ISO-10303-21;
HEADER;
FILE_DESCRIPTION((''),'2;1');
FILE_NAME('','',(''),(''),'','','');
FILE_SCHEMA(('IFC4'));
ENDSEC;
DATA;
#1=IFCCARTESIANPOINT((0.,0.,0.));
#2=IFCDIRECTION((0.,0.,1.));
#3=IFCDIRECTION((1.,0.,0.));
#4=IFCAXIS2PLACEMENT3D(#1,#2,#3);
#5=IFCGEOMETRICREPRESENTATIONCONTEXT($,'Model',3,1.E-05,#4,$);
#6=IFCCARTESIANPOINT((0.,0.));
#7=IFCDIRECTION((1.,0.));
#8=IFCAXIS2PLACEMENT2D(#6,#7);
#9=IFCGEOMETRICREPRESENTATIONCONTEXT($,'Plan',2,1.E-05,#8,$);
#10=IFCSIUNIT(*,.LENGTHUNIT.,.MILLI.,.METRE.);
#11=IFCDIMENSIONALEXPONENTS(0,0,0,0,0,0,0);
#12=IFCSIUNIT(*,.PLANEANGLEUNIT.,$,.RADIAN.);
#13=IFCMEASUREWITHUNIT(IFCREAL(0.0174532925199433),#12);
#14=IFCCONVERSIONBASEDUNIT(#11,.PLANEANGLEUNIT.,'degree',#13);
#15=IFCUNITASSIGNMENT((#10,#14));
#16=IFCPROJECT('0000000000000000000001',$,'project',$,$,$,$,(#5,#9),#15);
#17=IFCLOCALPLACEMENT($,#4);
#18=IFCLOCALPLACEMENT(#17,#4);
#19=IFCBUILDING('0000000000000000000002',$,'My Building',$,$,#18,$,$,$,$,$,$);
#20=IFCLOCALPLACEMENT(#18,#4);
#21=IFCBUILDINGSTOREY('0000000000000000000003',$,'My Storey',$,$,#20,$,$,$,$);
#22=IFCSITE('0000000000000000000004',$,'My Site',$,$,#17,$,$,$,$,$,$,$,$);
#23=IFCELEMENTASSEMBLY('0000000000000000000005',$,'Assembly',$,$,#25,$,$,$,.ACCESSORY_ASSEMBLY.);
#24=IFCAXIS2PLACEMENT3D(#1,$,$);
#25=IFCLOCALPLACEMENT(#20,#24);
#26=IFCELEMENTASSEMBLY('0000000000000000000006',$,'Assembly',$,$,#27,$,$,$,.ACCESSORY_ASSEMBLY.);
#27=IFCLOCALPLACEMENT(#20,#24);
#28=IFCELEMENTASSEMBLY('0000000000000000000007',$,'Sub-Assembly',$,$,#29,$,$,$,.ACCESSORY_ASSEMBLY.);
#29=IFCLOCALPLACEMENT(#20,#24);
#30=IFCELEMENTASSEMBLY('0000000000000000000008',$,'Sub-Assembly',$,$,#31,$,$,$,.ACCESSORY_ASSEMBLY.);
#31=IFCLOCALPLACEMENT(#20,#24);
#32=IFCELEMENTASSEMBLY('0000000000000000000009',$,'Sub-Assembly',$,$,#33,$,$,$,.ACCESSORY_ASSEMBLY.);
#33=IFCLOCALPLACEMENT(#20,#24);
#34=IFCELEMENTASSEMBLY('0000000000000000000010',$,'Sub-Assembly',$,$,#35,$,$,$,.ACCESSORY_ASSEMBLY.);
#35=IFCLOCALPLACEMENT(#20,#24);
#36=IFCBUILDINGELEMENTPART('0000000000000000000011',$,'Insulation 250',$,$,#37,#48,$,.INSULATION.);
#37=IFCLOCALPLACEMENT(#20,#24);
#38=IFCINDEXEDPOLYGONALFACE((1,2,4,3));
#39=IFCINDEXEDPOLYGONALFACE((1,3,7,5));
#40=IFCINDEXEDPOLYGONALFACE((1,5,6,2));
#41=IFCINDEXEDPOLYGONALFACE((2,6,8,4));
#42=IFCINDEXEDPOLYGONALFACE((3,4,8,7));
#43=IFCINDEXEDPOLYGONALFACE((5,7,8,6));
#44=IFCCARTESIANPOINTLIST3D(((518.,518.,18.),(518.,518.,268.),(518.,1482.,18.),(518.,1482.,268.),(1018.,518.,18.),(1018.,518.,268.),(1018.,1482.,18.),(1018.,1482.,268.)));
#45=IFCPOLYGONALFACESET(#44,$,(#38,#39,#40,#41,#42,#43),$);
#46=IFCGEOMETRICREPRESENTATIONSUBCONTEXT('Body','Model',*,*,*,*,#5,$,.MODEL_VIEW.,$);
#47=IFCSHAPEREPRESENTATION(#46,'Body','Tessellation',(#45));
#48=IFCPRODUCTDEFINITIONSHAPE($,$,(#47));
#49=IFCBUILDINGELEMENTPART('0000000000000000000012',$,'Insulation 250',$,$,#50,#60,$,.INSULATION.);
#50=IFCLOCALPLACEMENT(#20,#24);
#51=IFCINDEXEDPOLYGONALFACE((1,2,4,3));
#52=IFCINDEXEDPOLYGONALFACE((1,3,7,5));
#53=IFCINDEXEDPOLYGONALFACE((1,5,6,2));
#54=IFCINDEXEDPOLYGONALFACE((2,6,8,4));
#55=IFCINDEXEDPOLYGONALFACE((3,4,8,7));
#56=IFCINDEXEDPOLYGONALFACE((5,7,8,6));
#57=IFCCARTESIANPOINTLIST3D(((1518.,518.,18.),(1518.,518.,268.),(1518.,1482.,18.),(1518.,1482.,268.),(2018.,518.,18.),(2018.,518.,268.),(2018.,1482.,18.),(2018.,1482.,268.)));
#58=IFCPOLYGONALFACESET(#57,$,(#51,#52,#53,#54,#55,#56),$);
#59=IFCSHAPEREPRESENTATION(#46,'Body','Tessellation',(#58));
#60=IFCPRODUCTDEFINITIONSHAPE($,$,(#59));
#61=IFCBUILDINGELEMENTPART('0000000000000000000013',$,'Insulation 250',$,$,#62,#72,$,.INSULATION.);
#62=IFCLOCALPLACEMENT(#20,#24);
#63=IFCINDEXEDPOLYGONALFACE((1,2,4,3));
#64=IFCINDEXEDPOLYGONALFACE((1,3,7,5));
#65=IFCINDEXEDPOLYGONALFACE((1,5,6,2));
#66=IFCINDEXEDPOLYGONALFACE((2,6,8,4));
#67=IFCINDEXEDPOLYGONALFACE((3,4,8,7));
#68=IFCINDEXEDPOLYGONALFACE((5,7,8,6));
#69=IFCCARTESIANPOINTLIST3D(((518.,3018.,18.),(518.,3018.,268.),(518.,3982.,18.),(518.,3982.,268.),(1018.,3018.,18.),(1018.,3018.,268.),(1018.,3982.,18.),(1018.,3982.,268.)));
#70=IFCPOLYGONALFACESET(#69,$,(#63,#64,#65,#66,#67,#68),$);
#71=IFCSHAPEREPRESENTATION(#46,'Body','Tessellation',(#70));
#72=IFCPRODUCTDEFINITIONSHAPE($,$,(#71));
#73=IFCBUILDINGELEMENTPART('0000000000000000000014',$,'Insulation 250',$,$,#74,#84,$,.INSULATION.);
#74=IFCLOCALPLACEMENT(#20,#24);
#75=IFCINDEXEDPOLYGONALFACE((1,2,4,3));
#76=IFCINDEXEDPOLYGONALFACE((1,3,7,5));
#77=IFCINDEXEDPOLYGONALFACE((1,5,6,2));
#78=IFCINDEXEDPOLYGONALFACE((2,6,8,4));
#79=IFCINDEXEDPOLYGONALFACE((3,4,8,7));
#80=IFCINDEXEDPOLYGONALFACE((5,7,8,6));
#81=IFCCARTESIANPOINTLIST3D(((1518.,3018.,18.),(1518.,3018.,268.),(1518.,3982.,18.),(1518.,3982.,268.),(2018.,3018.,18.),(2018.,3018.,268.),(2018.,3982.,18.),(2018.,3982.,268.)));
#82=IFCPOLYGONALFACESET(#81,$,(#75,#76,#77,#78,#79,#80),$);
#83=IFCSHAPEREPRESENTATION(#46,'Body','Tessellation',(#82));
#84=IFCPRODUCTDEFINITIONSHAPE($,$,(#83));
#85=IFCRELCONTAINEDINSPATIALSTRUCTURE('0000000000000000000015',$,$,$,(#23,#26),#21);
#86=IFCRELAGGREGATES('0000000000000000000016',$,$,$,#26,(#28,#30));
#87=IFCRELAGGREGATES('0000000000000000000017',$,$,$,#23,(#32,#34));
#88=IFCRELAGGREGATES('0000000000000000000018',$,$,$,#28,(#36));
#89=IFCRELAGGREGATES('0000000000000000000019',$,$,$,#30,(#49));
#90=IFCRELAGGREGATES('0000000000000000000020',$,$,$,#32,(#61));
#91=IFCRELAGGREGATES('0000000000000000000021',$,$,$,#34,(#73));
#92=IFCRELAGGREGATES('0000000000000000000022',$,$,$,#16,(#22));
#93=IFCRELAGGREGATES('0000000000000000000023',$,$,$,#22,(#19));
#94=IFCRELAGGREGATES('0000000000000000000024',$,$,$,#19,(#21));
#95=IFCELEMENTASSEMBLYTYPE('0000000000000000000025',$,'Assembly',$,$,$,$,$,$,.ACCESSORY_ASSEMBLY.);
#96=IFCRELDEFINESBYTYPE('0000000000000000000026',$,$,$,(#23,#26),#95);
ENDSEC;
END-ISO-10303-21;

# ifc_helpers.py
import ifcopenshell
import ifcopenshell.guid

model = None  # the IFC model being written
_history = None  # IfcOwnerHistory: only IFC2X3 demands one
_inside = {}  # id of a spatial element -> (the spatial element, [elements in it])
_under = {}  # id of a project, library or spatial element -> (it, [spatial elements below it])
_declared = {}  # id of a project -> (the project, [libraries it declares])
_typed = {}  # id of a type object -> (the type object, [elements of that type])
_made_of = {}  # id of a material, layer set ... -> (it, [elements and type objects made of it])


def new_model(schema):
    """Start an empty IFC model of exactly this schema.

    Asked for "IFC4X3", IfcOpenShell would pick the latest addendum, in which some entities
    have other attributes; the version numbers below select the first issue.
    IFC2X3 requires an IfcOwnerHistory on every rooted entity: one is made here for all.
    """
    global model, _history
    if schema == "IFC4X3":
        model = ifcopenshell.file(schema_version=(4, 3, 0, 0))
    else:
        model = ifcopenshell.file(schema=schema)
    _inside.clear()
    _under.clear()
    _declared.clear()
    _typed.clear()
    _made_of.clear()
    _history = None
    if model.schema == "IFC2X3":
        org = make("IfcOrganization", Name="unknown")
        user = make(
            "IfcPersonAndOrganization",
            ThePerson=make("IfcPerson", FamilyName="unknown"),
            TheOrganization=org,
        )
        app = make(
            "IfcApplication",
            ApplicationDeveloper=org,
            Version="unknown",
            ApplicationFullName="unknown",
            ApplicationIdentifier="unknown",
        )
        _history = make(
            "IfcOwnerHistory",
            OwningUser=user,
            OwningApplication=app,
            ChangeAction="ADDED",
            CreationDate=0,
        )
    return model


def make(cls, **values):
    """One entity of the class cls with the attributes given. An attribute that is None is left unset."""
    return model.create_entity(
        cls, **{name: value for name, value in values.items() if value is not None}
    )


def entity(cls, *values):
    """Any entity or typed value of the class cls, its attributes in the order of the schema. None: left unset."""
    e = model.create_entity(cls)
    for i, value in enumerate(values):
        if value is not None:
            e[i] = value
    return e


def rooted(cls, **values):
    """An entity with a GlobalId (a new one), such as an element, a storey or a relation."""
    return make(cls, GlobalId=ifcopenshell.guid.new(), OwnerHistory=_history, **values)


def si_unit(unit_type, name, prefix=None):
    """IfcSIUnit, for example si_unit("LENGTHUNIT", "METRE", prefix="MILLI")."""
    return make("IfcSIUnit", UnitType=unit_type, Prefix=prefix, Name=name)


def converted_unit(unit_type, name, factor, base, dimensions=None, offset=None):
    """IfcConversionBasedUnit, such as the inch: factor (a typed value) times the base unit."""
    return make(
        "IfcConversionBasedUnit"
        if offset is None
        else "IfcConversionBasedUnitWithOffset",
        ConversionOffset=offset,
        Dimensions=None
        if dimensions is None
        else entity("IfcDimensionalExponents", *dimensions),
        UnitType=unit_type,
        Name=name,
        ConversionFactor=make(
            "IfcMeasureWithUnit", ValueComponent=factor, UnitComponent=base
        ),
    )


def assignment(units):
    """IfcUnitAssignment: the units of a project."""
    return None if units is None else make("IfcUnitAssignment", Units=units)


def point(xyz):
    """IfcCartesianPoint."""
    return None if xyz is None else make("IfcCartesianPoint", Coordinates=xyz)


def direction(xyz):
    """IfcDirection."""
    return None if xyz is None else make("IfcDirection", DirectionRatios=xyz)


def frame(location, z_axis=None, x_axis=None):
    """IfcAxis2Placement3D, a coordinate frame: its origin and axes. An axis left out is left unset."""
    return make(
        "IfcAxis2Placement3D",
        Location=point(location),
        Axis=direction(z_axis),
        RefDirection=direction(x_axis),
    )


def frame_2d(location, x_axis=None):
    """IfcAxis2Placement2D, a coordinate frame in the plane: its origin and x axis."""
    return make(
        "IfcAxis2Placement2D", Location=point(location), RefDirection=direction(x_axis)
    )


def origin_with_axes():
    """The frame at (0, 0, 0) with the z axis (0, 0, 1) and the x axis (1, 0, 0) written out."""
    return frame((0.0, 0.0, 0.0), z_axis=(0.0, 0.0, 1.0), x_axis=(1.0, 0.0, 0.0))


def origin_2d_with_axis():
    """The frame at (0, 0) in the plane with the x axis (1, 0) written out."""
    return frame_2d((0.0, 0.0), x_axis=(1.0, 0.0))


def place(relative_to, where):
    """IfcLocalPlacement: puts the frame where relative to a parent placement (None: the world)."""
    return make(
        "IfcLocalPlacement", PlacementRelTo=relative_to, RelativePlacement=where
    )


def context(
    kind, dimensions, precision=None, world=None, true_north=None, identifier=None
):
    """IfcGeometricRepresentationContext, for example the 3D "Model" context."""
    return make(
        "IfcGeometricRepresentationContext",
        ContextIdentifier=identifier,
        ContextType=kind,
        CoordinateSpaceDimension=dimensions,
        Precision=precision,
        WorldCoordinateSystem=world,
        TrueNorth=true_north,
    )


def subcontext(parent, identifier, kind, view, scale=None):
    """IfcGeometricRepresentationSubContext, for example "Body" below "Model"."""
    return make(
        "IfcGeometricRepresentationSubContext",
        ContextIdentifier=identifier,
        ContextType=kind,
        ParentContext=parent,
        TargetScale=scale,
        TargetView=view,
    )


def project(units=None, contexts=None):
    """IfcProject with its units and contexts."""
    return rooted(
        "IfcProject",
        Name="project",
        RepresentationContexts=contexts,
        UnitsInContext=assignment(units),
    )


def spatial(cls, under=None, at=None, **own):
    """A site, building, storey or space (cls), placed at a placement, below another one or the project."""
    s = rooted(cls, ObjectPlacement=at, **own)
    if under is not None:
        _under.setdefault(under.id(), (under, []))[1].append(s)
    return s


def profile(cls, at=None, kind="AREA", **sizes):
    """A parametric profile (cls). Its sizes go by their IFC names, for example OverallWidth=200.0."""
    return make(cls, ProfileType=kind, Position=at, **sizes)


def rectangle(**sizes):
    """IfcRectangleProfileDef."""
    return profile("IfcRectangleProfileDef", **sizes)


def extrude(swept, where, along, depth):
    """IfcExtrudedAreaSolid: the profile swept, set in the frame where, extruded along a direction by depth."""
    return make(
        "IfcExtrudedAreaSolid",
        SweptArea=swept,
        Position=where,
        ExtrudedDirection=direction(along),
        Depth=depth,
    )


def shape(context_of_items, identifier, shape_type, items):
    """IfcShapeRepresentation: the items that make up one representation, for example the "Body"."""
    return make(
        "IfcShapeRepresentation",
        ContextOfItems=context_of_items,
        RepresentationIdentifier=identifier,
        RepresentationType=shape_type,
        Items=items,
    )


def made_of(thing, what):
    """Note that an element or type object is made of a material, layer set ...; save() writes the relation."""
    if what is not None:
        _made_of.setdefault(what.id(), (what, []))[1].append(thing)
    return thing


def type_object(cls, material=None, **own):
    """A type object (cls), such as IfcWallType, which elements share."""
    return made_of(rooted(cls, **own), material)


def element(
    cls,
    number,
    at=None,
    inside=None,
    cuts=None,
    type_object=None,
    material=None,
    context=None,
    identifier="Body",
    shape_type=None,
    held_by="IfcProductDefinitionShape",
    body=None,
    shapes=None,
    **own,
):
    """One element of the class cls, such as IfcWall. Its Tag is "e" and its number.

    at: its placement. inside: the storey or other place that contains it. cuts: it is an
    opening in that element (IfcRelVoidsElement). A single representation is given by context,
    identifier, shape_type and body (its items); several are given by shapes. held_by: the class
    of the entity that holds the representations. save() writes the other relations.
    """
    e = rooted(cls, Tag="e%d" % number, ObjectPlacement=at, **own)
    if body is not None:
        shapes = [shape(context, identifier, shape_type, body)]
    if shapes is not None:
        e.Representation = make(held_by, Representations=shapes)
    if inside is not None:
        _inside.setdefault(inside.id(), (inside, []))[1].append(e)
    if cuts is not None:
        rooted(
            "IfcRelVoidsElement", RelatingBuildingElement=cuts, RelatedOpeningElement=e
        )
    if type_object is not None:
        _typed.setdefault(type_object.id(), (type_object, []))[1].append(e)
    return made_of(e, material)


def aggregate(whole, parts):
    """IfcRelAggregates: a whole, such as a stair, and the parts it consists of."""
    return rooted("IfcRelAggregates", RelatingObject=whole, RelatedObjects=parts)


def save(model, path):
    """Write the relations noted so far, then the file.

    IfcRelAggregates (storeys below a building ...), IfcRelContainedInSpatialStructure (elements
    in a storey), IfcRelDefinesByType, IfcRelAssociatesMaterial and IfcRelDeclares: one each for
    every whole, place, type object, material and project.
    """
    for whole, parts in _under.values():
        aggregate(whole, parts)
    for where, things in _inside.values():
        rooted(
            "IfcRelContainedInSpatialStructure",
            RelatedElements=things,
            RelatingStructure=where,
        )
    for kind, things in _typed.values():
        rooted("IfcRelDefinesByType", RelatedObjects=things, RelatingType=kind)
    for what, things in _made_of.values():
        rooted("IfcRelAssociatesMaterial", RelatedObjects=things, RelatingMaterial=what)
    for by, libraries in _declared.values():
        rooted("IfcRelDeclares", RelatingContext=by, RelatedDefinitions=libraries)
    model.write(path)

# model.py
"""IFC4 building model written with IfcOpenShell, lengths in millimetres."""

from ifc_helpers import new_model, entity, si_unit, converted_unit, frame, origin_with_axes, origin_2d_with_axis, place, context, subcontext, project, spatial, rectangle, extrude, type_object, element, aggregate, save


model = new_model("IFC4")

# Units and contexts
model_context = context("Model", 3, precision=1e-05, world=origin_with_axes())
plan_context = context("Plan", 2, precision=1e-05, world=origin_2d_with_axis())
body_context = subcontext(model_context, "Body", "Model", "MODEL_VIEW")
ifc_project = project(units=[si_unit("LENGTHUNIT", "METRE", prefix="MILLI"), converted_unit("PLANEANGLEUNIT", "degree", entity("IfcReal", 0.0174532925199433), si_unit("PLANEANGLEUNIT", "RADIAN"), dimensions=[0, 0, 0, 0, 0, 0, 0])], contexts=[model_context, plan_context])

# Site, building, storey
site_placement = place(None, origin_with_axes())
site = spatial("IfcSite", under=ifc_project, at=site_placement, Name="My Site")
building_placement = place(site_placement, origin_with_axes())
building = spatial("IfcBuilding", under=site, at=building_placement, Name="My Building")
storey_placement = place(building_placement, origin_with_axes())
storey = spatial("IfcBuildingStorey", under=building, at=storey_placement, Name="My Storey")

# Element assembly
element_assembly_type_1 = type_object("IfcElementAssemblyType", Name="Assembly", PredefinedType="ACCESSORY_ASSEMBLY")
assembly_1_placement = place(storey_placement, frame((0.0, 2500.0, 0.0)))
assembly_1 = element("IfcElementAssembly", 1, at=assembly_1_placement, inside=storey, type_object=element_assembly_type_1, Name="Assembly", PredefinedType="ACCESSORY_ASSEMBLY")

# Element assemblies
assembly_2_placement = place(storey_placement, origin_with_axes())
assembly_2 = element("IfcElementAssembly", 2, at=assembly_2_placement, inside=storey, type_object=element_assembly_type_1, Name="Assembly", PredefinedType="ACCESSORY_ASSEMBLY")
assembly_3_placement = place(assembly_2_placement, frame((500.0, 500.0, 0.0)))
assembly_3 = element("IfcElementAssembly", 3, at=assembly_3_placement, Name="Sub-Assembly", PredefinedType="ACCESSORY_ASSEMBLY")
assembly_4_placement = place(assembly_2_placement, frame((1500.0, 500.0, 0.0)))
assembly_4 = element("IfcElementAssembly", 4, at=assembly_4_placement, Name="Sub-Assembly", PredefinedType="ACCESSORY_ASSEMBLY")
aggregate(assembly_2, [assembly_3, assembly_4])

# Element assembly
assembly_5_placement = place(assembly_1_placement, frame((500.0, 500.0, 0.0)))
assembly_5 = element("IfcElementAssembly", 5, at=assembly_5_placement, Name="Sub-Assembly", PredefinedType="ACCESSORY_ASSEMBLY")

# Element assembly
assembly_6_placement = place(assembly_1_placement, frame((1500.0, 500.0, 0.0)))
assembly_6 = element("IfcElementAssembly", 6, at=assembly_6_placement, Name="Sub-Assembly", PredefinedType="ACCESSORY_ASSEMBLY")
aggregate(assembly_1, [assembly_5, assembly_6])

# Building element parts
building_element_part_1_placement = place(assembly_3_placement, frame((268.0, 500.0, 18.0), z_axis=(0.0, 0.0, 1.0), x_axis=(1.0, 0.0, 0.0)))
building_element_part_1 = element("IfcBuildingElementPart", 7, at=building_element_part_1_placement, Name="Insulation 250", PredefinedType="INSULATION", context=body_context, shape_type="SweptSolid", body=[
    extrude(rectangle(XDim=500.0, YDim=964.0), None, (0.0, 0.0, 1.0), 250.0),
])
aggregate(assembly_3, [building_element_part_1])
building_element_part_2_placement = place(assembly_4_placement, frame((268.0, 500.0, 18.0), z_axis=(0.0, 0.0, 1.0), x_axis=(1.0, 0.0, 0.0)))
building_element_part_2 = element("IfcBuildingElementPart", 8, at=building_element_part_2_placement, Name="Insulation 250", PredefinedType="INSULATION", context=body_context, shape_type="SweptSolid", body=[
    extrude(rectangle(XDim=500.0, YDim=964.0), None, (0.0, 0.0, 1.0), 250.0),
])
aggregate(assembly_4, [building_element_part_2])
building_element_part_3_placement = place(assembly_5_placement, frame((268.0, 500.0, 18.0), z_axis=(0.0, 0.0, 1.0), x_axis=(1.0, 0.0, 0.0)))
building_element_part_3 = element("IfcBuildingElementPart", 9, at=building_element_part_3_placement, Name="Insulation 250", PredefinedType="INSULATION", context=body_context, shape_type="SweptSolid", body=[
    extrude(rectangle(XDim=500.0, YDim=964.0), None, (0.0, 0.0, 1.0), 250.0),
])
aggregate(assembly_5, [building_element_part_3])
building_element_part_4_placement = place(assembly_6_placement, frame((268.0, 500.0, 18.0), z_axis=(0.0, 0.0, 1.0), x_axis=(1.0, 0.0, 0.0)))
building_element_part_4 = element("IfcBuildingElementPart", 10, at=building_element_part_4_placement, Name="Insulation 250", PredefinedType="INSULATION", context=body_context, shape_type="SweptSolid", body=[
    extrude(rectangle(XDim=500.0, YDim=964.0), None, (0.0, 0.0, 1.0), 250.0),
])
aggregate(assembly_6, [building_element_part_4])

save(model, "model.ifc")
